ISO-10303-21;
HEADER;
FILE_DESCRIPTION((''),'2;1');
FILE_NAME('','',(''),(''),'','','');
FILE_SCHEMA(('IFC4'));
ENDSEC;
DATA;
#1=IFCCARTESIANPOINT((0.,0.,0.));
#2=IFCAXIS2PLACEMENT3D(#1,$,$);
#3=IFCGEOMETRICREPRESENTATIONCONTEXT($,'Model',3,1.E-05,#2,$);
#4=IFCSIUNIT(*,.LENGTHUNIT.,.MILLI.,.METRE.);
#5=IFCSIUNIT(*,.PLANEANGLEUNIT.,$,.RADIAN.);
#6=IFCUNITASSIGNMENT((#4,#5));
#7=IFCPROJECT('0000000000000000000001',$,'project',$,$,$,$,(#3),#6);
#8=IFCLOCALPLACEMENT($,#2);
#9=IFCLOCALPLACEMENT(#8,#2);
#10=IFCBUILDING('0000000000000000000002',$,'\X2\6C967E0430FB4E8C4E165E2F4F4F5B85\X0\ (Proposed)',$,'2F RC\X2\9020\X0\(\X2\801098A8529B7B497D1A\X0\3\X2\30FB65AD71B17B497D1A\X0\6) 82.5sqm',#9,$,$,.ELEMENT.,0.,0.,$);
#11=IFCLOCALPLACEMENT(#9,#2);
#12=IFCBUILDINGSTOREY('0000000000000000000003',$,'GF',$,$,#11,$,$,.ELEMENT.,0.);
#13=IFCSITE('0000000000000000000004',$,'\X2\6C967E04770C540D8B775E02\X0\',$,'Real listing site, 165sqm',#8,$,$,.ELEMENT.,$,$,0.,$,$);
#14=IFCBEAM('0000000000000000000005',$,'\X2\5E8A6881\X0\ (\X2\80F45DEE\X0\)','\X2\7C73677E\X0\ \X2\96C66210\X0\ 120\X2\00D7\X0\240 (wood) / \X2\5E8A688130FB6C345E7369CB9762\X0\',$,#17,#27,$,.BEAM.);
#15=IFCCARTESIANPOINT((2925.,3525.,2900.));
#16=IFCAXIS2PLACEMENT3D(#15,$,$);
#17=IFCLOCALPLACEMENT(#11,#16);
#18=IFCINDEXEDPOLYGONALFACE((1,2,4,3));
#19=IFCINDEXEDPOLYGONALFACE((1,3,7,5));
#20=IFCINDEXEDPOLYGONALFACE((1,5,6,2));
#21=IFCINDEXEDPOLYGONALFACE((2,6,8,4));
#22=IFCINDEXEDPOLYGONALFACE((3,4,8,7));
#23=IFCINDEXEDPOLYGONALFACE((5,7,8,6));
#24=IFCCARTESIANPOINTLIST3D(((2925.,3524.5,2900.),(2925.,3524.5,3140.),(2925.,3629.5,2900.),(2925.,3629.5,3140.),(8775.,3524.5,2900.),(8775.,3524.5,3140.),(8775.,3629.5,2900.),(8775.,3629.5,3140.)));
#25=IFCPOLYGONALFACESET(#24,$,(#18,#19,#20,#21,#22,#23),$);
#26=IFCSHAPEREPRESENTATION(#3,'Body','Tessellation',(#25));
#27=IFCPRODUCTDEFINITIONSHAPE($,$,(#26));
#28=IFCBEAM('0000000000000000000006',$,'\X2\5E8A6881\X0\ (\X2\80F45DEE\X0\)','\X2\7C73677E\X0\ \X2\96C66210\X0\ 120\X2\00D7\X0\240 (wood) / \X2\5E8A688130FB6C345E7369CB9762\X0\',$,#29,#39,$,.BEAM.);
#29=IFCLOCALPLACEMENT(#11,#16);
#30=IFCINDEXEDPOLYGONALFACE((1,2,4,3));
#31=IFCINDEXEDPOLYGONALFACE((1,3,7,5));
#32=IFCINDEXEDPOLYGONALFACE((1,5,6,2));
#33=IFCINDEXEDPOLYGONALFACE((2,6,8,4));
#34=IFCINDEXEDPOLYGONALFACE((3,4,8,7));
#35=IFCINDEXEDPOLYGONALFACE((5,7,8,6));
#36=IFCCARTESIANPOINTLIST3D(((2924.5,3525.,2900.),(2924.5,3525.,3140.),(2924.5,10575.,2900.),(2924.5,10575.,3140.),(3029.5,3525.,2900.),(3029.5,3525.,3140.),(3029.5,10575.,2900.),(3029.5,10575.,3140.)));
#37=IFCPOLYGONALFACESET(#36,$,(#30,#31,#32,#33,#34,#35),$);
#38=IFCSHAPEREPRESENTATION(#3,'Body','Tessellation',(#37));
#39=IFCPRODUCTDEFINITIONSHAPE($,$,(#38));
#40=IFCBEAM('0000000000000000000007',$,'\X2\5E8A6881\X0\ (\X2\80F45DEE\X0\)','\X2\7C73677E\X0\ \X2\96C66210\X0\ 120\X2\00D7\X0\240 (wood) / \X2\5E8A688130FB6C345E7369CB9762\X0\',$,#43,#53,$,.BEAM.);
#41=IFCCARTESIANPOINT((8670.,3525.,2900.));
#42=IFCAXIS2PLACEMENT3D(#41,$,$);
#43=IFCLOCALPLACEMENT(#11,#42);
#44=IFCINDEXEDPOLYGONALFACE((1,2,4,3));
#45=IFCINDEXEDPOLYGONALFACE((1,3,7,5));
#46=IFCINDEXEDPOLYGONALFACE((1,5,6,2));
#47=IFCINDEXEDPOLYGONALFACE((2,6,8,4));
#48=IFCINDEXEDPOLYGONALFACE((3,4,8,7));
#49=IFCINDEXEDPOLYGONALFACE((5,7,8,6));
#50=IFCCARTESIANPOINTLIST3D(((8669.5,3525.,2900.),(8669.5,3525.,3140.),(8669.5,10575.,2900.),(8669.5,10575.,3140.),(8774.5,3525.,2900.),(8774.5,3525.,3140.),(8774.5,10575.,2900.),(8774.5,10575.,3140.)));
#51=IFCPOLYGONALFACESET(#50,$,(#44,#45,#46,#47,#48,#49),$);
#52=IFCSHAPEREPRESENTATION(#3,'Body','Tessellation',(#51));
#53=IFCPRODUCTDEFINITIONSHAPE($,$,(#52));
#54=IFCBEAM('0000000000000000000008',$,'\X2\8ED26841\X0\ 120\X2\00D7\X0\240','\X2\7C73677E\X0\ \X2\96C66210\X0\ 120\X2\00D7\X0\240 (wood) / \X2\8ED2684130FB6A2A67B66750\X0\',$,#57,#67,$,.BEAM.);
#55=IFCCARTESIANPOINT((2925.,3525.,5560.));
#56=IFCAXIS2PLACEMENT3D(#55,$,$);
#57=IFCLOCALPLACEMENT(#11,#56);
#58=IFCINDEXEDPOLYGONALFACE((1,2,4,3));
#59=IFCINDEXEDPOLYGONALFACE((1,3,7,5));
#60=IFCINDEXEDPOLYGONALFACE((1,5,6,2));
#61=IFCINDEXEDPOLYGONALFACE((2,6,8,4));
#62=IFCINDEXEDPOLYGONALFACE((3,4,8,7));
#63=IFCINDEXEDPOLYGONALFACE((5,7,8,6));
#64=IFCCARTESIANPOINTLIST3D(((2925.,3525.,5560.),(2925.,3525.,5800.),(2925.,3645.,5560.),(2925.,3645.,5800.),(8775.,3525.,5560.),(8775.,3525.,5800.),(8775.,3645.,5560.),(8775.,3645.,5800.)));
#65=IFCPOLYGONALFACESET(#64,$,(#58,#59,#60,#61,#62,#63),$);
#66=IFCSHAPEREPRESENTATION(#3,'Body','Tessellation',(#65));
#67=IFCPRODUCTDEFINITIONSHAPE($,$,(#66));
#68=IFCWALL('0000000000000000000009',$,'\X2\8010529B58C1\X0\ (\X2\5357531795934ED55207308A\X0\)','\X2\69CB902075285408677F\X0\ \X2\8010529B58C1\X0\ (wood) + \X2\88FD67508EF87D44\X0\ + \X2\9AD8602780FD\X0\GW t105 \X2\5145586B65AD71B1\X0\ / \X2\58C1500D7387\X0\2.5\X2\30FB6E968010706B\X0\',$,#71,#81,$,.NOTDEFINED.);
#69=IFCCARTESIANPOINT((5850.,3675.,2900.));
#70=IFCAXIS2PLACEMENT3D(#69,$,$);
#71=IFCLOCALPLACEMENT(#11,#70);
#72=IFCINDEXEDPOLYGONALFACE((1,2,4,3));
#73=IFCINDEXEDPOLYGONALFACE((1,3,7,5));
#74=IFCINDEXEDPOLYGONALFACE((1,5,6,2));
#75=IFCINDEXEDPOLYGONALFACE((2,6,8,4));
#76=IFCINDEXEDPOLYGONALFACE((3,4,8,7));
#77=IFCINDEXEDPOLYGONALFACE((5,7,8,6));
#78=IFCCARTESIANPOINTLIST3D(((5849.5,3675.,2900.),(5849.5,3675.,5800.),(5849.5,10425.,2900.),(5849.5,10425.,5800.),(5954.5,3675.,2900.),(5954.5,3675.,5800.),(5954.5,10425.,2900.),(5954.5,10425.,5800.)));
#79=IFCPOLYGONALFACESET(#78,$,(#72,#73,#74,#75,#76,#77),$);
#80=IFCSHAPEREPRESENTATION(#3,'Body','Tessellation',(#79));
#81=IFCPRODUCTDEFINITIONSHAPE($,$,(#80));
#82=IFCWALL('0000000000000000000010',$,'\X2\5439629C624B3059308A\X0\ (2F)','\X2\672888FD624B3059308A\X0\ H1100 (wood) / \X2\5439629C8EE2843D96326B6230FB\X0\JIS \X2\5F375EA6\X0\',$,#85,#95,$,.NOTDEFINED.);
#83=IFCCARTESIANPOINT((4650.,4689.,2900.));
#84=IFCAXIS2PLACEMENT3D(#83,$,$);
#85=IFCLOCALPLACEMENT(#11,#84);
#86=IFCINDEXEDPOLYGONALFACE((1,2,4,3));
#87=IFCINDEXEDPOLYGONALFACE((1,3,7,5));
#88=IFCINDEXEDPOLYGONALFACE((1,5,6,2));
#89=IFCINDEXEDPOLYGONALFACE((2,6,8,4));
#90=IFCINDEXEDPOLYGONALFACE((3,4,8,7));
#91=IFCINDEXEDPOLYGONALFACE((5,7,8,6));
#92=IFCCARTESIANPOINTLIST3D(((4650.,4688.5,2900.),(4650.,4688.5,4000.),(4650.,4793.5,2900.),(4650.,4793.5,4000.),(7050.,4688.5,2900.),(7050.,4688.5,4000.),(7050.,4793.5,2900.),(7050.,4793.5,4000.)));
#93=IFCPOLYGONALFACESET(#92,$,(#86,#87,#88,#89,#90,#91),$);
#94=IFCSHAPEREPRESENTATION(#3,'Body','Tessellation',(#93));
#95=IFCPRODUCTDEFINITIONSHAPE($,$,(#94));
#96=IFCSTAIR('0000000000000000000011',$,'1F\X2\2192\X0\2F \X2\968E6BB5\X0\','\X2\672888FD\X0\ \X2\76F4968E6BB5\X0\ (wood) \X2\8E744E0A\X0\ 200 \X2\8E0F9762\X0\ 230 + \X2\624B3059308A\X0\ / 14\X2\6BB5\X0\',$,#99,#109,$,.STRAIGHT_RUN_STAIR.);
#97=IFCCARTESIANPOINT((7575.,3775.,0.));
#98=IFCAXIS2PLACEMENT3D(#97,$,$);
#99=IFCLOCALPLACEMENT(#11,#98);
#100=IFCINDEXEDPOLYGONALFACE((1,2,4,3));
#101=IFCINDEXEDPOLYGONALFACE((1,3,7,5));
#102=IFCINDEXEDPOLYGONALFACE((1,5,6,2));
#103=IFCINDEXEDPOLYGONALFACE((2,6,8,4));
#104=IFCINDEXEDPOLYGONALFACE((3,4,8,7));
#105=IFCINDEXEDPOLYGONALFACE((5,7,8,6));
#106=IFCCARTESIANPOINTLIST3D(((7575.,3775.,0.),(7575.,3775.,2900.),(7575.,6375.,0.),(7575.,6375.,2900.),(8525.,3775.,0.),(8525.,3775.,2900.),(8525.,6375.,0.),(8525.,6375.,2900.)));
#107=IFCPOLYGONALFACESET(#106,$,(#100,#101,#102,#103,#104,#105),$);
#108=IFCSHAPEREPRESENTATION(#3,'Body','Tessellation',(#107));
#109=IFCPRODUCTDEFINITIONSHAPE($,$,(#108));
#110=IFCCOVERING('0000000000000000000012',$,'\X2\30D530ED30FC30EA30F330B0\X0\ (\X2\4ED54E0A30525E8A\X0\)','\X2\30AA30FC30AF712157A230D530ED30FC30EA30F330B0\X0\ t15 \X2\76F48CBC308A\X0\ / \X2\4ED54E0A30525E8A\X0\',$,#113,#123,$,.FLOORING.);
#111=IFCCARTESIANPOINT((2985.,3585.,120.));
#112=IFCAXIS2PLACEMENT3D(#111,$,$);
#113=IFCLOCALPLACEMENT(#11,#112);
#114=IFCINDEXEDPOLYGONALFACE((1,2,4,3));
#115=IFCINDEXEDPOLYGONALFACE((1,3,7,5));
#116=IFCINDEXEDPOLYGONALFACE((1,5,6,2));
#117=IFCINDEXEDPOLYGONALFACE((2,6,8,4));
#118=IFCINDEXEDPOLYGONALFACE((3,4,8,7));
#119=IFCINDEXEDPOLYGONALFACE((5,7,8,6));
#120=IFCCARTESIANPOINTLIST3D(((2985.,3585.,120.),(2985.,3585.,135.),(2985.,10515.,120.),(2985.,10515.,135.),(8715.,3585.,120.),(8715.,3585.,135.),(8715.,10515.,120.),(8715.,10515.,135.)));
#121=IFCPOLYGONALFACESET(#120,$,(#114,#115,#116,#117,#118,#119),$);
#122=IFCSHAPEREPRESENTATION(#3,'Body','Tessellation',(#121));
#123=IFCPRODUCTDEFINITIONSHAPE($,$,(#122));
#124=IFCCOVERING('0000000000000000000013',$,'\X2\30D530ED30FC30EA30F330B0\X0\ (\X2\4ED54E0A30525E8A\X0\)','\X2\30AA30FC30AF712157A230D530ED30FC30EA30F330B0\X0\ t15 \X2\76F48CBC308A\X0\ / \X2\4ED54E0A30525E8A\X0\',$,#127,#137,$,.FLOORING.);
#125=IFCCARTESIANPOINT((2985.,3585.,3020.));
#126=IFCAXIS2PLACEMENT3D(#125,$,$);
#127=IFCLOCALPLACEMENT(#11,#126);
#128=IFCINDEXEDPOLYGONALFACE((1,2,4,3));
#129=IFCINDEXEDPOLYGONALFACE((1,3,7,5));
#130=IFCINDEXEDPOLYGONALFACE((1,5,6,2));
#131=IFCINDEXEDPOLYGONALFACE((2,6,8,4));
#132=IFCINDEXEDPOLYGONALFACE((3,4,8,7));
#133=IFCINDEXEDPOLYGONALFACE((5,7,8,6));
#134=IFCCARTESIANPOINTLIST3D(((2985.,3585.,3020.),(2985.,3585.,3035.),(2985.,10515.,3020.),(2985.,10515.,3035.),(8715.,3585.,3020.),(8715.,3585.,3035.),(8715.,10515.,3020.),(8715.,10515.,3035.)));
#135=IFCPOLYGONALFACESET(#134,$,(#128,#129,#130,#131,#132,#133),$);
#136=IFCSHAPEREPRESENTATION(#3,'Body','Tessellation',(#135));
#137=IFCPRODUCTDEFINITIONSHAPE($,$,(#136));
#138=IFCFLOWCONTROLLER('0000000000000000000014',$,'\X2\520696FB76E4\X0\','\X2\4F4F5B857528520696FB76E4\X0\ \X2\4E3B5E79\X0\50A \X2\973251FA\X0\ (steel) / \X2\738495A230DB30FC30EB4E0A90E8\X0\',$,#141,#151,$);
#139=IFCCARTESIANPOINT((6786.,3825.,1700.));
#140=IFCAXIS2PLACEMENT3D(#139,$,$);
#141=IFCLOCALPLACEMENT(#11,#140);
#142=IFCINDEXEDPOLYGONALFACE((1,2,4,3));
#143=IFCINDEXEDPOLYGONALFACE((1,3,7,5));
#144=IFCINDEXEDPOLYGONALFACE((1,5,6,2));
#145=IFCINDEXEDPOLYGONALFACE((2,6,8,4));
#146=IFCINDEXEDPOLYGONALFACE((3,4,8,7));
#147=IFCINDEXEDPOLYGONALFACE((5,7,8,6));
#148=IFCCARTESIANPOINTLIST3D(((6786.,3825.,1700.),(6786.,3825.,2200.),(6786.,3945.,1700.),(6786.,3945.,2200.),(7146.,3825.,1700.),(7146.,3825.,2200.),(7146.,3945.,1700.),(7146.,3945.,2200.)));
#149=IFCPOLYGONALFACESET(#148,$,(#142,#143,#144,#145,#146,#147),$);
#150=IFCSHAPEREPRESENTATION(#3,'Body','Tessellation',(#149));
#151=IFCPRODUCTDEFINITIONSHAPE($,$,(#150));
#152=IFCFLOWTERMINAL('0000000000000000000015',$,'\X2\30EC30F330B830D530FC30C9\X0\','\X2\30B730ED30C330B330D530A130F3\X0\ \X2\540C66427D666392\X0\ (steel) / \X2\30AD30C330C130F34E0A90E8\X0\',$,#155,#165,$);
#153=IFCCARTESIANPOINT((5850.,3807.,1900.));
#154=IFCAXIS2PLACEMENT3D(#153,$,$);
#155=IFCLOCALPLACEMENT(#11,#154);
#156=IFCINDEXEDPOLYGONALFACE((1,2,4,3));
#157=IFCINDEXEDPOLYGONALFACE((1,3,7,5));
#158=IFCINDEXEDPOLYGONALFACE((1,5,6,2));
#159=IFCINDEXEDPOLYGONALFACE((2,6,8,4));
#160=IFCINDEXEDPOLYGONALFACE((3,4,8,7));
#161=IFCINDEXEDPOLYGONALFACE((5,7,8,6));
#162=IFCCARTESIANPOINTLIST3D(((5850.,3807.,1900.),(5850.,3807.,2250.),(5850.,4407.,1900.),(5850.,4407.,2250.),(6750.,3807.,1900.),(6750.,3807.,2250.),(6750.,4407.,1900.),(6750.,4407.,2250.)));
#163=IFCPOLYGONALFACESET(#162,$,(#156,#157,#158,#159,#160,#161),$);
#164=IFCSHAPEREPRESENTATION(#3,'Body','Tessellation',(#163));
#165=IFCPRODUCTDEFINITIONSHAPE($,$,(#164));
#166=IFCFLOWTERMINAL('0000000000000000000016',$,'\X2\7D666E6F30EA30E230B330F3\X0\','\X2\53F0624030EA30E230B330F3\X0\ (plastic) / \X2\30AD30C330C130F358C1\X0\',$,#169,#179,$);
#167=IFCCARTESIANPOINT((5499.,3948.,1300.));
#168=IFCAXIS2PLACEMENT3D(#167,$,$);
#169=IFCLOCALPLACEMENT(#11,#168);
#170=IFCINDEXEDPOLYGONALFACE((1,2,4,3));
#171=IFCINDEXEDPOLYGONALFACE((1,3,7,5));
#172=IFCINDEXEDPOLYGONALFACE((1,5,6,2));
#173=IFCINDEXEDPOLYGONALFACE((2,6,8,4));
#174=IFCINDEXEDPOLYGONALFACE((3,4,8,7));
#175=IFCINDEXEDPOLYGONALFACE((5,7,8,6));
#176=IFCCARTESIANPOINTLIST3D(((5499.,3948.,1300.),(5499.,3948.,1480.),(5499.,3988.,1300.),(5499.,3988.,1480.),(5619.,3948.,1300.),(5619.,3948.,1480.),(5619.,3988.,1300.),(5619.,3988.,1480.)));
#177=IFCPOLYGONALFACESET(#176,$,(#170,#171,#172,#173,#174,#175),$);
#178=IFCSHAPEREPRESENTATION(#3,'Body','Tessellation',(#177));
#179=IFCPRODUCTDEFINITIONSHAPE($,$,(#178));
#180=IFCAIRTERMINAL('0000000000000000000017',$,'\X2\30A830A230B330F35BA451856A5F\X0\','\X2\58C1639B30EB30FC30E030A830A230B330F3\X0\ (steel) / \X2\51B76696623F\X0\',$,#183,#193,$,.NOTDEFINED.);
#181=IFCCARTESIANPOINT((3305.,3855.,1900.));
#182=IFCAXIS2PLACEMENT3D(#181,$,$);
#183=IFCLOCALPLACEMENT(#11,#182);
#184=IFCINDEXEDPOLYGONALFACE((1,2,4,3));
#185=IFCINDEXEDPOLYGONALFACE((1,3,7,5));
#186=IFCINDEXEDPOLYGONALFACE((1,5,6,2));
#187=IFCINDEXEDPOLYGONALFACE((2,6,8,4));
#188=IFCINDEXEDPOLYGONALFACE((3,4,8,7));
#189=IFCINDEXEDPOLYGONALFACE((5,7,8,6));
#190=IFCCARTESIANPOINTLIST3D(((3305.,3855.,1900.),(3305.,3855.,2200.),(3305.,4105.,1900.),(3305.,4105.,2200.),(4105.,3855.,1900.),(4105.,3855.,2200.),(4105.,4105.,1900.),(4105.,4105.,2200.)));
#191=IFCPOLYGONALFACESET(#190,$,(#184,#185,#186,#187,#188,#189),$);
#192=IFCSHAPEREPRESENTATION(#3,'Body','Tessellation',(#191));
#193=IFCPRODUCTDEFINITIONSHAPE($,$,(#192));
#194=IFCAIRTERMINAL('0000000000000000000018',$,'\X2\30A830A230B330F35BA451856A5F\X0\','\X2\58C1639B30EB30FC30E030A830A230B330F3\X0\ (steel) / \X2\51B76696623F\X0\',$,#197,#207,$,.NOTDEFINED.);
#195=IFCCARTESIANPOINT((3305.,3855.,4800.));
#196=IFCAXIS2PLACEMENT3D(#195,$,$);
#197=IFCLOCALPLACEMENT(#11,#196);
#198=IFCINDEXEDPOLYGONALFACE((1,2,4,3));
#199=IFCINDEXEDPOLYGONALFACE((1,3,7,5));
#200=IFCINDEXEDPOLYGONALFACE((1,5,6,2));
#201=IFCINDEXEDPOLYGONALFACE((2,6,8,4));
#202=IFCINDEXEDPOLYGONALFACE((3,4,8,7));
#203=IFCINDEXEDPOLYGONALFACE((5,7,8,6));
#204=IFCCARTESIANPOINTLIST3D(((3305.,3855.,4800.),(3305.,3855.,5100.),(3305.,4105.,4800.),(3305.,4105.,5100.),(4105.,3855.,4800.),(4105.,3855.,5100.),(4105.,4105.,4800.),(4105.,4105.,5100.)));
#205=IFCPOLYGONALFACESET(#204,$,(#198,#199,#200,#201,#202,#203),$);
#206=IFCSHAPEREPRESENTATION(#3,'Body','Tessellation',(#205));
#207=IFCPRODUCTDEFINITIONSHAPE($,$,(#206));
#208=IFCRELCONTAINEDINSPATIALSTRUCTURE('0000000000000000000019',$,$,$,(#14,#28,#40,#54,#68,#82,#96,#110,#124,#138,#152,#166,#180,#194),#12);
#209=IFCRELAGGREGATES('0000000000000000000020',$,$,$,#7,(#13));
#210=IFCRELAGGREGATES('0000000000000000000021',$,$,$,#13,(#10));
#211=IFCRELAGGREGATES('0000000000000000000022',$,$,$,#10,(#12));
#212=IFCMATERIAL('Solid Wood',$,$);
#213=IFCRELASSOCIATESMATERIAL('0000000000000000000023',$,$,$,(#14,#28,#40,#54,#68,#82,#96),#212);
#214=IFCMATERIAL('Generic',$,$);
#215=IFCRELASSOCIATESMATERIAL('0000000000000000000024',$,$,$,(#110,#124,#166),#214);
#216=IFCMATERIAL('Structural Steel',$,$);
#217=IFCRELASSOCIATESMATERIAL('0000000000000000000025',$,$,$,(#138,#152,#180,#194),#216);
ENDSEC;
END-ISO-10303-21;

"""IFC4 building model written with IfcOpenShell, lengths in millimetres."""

from ifc_helpers import new_model, si_unit, frame, frame_2d, origin, place, context, project, spatial, rectangle, extrude, material, element, save


model = new_model("IFC4")

# Units and contexts
model_context = context("Model", 3, precision=1e-05, world=origin())
ifc_project = project(units=[si_unit("LENGTHUNIT", "METRE", prefix="MILLI"), si_unit("PLANEANGLEUNIT", "RADIAN")], contexts=[model_context])

# Site, building, storey
site_placement = place(None, origin())
site = spatial("IfcSite", under=ifc_project, at=site_placement, Name="沖縄県名護市", ObjectType="Real listing site, 165sqm", CompositionType="ELEMENT", RefElevation=0.0)
building_placement = place(site_placement, origin())
building = spatial("IfcBuilding", under=site, at=building_placement, Name="沖縄・二世帯住宅 (Proposed)", ObjectType="2F RC造(耐風力等級3・断熱等級6) 82.5sqm", CompositionType="ELEMENT", ElevationOfRefHeight=0.0, ElevationOfTerrain=0.0)
storey_placement = place(building_placement, origin())
storey = spatial("IfcBuildingStorey", under=building, at=storey_placement, Name="GF", CompositionType="ELEMENT", Elevation=0.0)

# Shared definitions
ifc_material_1 = material(Name="Solid Wood")

# Beams
beam_1_placement = place(storey_placement, frame((2925.0, 3525.0, 2900.0)))
element("IfcBeam", 1, at=beam_1_placement, inside=storey, material=ifc_material_1, Name="床梁 (胴差)", Description="米松 集成 120×240 (wood) / 床梁・水平構面", PredefinedType="BEAM", context=model_context, shape_type="SweptSolid", body=[
    extrude(rectangle(XDim=5850.0, YDim=105.0, at=frame_2d((2925.0, 52.0))), frame((2925.0, 3525.0, 2900.0)), (0.0, 0.0, 1.0), 240.0),
])
beam_2_placement = place(storey_placement, frame((2925.0, 3525.0, 2900.0)))
element("IfcBeam", 2, at=beam_2_placement, inside=storey, material=ifc_material_1, Name="床梁 (胴差)", Description="米松 集成 120×240 (wood) / 床梁・水平構面", PredefinedType="BEAM", context=model_context, shape_type="SweptSolid", body=[
    extrude(rectangle(XDim=105.0, YDim=7050.0, at=frame_2d((52.0, 3525.0))), frame((2925.0, 3525.0, 2900.0)), (0.0, 0.0, 1.0), 240.0),
])
beam_3_placement = place(storey_placement, frame((8670.0, 3525.0, 2900.0)))
element("IfcBeam", 3, at=beam_3_placement, inside=storey, material=ifc_material_1, Name="床梁 (胴差)", Description="米松 集成 120×240 (wood) / 床梁・水平構面", PredefinedType="BEAM", context=model_context, shape_type="SweptSolid", body=[
    extrude(rectangle(XDim=105.0, YDim=7050.0, at=frame_2d((52.0, 3525.0))), frame((8670.0, 3525.0, 2900.0)), (0.0, 0.0, 1.0), 240.0),
])
beam_4_placement = place(storey_placement, frame((2925.0, 3525.0, 5560.0)))
element("IfcBeam", 4, at=beam_4_placement, inside=storey, material=ifc_material_1, Name="軒桁 120×240", Description="米松 集成 120×240 (wood) / 軒桁・横架材", PredefinedType="BEAM", context=model_context, shape_type="SweptSolid", body=[
    extrude(rectangle(XDim=5850.0, YDim=120.0, at=frame_2d((2925.0, 60.0))), frame((2925.0, 3525.0, 5560.0)), (0.0, 0.0, 1.0), 240.0),
])

# Walls
wall_1_placement = place(storey_placement, frame((5850.0, 3675.0, 2900.0)))
element("IfcWall", 5, at=wall_1_placement, inside=storey, material=ifc_material_1, Name="耐力壁 (南北間仕切り)", Description="構造用合板 耐力壁 (wood) + 製材軸組 + 高性能GW t105 充填断熱 / 壁倍率2.5・準耐火", PredefinedType="NOTDEFINED", context=model_context, shape_type="SweptSolid", body=[
    extrude(rectangle(XDim=105.0, YDim=6750.0, at=frame_2d((52.0, 3375.0))), frame((5850.0, 3675.0, 2900.0)), (0.0, 0.0, 1.0), 2900.0),
])
wall_2_placement = place(storey_placement, frame((4650.0, 4689.0, 2900.0)))
element("IfcWall", 6, at=wall_2_placement, inside=storey, material=ifc_material_1, Name="吹抜手すり (2F)", Description="木製手すり H1100 (wood) / 吹抜転落防止・JIS 強度", PredefinedType="NOTDEFINED", context=model_context, shape_type="SweptSolid", body=[
    extrude(rectangle(XDim=2400.0, YDim=105.0, at=frame_2d((1200.0, 52.0))), frame((4650.0, 4689.0, 2900.0)), (0.0, 0.0, 1.0), 1100.0),
])

# Stair
stair_placement = place(storey_placement, frame((7575.0, 3775.0, 0.0)))
element("IfcStair", 7, at=stair_placement, inside=storey, material=ifc_material_1, Name="1F→2F 階段", Description="木製 直階段 (wood) 蹴上 200 踏面 230 + 手すり / 14段", PredefinedType="STRAIGHT_RUN_STAIR", context=model_context, shape_type="SweptSolid", body=[
    extrude(rectangle(XDim=950.0, YDim=2600.0, at=frame_2d((475.0, 1300.0))), frame((7575.0, 3775.0, 0.0)), (0.0, 0.0, 1.0), 2900.0),
])

# Coverings
ifc_material_2 = material(Name="Generic")
covering_1_placement = place(storey_placement, frame((2985.0, 3585.0, 120.0)))
element("IfcCovering", 8, at=covering_1_placement, inside=storey, material=ifc_material_2, Name="フローリング (仕上げ床)", Description="オーク無垢フローリング t15 直貼り / 仕上げ床", PredefinedType="FLOORING", context=model_context, shape_type="SweptSolid", body=[
    extrude(rectangle(XDim=5730.0, YDim=6930.0, at=frame_2d((2865.0, 3465.0))), frame((2985.0, 3585.0, 120.0)), (0.0, 0.0, 1.0), 15.0),
])
covering_2_placement = place(storey_placement, frame((2985.0, 3585.0, 3020.0)))
element("IfcCovering", 9, at=covering_2_placement, inside=storey, material=ifc_material_2, Name="フローリング (仕上げ床)", Description="オーク無垢フローリング t15 直貼り / 仕上げ床", PredefinedType="FLOORING", context=model_context, shape_type="SweptSolid", body=[
    extrude(rectangle(XDim=5730.0, YDim=6930.0, at=frame_2d((2865.0, 3465.0))), frame((2985.0, 3585.0, 3020.0)), (0.0, 0.0, 1.0), 15.0),
])

# Flow controller
ifc_material_3 = material(Name="Structural Steel")
flow_controller_placement = place(storey_placement, frame((6786.0, 3825.0, 1700.0)))
element("IfcFlowController", 10, at=flow_controller_placement, inside=storey, material=ifc_material_3, Name="分電盤", Description="住宅用分電盤 主幹50A 露出 (steel) / 玄関ホール上部", context=model_context, shape_type="SweptSolid", body=[
    extrude(rectangle(XDim=360.0, YDim=120.0, at=frame_2d((180.0, 60.0))), frame((6786.0, 3825.0, 1700.0)), (0.0, 0.0, 1.0), 500.0),
])

# Flow terminals
flow_terminal_1_placement = place(storey_placement, frame((5850.0, 3807.0, 1900.0)))
element("IfcFlowTerminal", 11, at=flow_terminal_1_placement, inside=storey, material=ifc_material_3, Name="レンジフード", Description="シロッコファン 同時給排 (steel) / キッチン上部", context=model_context, shape_type="SweptSolid", body=[
    extrude(rectangle(XDim=900.0, YDim=600.0, at=frame_2d((450.0, 300.0))), frame((5850.0, 3807.0, 1900.0)), (0.0, 0.0, 1.0), 350.0),
])
flow_terminal_2_placement = place(storey_placement, frame((5499.0, 3948.0, 1300.0)))
element("IfcFlowTerminal", 12, at=flow_terminal_2_placement, inside=storey, material=ifc_material_2, Name="給湯リモコン", Description="台所リモコン (plastic) / キッチン壁", context=model_context, shape_type="SweptSolid", body=[
    extrude(rectangle(XDim=120.0, YDim=40.0, at=frame_2d((60.0, 20.0))), frame((5499.0, 3948.0, 1300.0)), (0.0, 0.0, 1.0), 180.0),
])

# Air terminals
air_terminal_1_placement = place(storey_placement, frame((3305.0, 3855.0, 1900.0)))
element("IfcAirTerminal", 13, at=air_terminal_1_placement, inside=storey, material=ifc_material_3, Name="エアコン室内機", Description="壁掛ルームエアコン (steel) / 冷暖房", PredefinedType="NOTDEFINED", context=model_context, shape_type="SweptSolid", body=[
    extrude(rectangle(XDim=800.0, YDim=250.0, at=frame_2d((400.0, 125.0))), frame((3305.0, 3855.0, 1900.0)), (0.0, 0.0, 1.0), 300.0),
])
air_terminal_2_placement = place(storey_placement, frame((3305.0, 3855.0, 4800.0)))
element("IfcAirTerminal", 14, at=air_terminal_2_placement, inside=storey, material=ifc_material_3, Name="エアコン室内機", Description="壁掛ルームエアコン (steel) / 冷暖房", PredefinedType="NOTDEFINED", context=model_context, shape_type="SweptSolid", body=[
    extrude(rectangle(XDim=800.0, YDim=250.0, at=frame_2d((400.0, 125.0))), frame((3305.0, 3855.0, 4800.0)), (0.0, 0.0, 1.0), 300.0),
])

save(model, "model.ifc")
